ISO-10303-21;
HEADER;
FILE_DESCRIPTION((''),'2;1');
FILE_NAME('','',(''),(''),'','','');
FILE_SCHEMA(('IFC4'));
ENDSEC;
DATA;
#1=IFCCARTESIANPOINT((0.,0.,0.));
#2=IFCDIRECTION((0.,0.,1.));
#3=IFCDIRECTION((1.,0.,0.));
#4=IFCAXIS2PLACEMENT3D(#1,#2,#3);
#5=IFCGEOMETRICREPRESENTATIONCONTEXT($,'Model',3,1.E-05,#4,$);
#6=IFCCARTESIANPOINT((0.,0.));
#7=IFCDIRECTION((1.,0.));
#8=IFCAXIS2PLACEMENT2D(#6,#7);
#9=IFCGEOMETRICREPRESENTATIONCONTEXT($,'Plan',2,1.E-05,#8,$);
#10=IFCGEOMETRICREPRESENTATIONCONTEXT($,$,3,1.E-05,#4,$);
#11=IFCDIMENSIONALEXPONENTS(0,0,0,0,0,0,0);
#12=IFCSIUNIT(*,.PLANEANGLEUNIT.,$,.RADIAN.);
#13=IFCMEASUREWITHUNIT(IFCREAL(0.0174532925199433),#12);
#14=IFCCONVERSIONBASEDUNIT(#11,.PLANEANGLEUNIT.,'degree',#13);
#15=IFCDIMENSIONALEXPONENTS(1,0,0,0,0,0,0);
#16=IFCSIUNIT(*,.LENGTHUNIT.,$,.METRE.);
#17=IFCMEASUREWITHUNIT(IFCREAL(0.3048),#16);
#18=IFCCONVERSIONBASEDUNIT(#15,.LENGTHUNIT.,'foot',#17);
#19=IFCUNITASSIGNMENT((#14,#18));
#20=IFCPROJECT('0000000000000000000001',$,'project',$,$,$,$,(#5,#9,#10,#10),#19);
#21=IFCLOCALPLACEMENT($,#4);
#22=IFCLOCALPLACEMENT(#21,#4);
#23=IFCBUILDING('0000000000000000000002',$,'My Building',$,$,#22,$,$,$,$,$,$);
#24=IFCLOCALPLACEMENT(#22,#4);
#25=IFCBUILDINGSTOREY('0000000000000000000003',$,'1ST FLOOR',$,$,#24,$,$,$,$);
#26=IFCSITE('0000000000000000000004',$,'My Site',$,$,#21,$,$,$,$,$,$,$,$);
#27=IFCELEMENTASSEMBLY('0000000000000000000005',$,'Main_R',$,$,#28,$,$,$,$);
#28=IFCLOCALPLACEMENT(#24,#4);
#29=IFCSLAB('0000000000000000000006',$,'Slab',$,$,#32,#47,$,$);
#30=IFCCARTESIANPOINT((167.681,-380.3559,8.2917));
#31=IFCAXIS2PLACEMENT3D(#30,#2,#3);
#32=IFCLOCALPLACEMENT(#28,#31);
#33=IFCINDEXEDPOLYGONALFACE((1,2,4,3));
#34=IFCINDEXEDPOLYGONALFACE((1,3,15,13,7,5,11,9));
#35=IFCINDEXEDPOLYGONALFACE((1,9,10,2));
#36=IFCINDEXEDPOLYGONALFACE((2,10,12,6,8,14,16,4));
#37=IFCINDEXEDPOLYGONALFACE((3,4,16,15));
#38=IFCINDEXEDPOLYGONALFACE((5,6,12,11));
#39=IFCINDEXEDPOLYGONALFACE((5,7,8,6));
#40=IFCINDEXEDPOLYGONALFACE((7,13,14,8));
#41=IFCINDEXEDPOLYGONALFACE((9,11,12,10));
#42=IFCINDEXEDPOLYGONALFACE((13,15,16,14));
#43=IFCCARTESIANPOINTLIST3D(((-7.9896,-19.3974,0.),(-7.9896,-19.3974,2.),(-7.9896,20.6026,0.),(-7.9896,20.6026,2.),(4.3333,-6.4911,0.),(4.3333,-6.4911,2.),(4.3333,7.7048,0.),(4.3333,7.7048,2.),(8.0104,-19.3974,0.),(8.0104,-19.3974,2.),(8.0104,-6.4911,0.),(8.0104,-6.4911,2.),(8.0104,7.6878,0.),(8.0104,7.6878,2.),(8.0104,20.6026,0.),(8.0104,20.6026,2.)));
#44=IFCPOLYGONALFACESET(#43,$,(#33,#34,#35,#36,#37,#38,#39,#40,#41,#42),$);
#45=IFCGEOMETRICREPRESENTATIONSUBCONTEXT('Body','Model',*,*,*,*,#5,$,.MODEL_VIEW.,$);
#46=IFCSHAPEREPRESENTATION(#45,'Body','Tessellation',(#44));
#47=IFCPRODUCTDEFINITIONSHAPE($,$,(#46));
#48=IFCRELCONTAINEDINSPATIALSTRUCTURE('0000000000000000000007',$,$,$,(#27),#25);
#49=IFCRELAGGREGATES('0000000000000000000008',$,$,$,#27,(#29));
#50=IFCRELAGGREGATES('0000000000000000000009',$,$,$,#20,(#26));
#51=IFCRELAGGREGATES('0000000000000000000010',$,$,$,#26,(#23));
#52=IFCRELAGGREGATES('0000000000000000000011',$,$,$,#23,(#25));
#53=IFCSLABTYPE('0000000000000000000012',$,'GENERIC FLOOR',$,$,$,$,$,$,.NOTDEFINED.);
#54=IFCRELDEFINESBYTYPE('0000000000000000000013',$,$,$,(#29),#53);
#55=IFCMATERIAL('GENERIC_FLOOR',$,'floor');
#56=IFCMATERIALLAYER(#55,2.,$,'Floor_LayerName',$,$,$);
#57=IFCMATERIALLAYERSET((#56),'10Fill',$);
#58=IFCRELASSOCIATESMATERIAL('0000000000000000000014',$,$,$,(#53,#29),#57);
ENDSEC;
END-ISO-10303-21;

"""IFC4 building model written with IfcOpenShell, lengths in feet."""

from ifc_helpers import new_model, entity, si_unit, converted_unit, frame, origin_with_axes, origin_2d_with_axis, place, context, subcontext, project, spatial, line, indexed_curve, outline, extrude, material, layer, layer_set, layer_usage, type_object, element, aggregate, save


model = new_model("IFC4")

# Units and contexts
model_context = context("Model", 3, precision=1e-05, world=origin_with_axes())
plan_context = context("Plan", 2, precision=1e-05, world=origin_2d_with_axis())
context_of_model = context(None, 3, precision=1e-05, world=origin_with_axes())
body_context = subcontext(model_context, "Body", "Model", "MODEL_VIEW")
ifc_project = project(units=[converted_unit("PLANEANGLEUNIT", "degree", entity("IfcReal", 0.0174532925199433), si_unit("PLANEANGLEUNIT", "RADIAN"), dimensions=[0, 0, 0, 0, 0, 0, 0]), converted_unit("LENGTHUNIT", "foot", entity("IfcReal", 0.3048), si_unit("LENGTHUNIT", "METRE"), dimensions=[1, 0, 0, 0, 0, 0, 0])], contexts=[model_context, plan_context, context_of_model, context_of_model])

# Site, building, storey
site_placement = place(None, origin_with_axes())
site = spatial("IfcSite", under=ifc_project, at=site_placement, Name="My Site")
building_placement = place(site_placement, origin_with_axes())
building = spatial("IfcBuilding", under=site, at=building_placement, Name="My Building")
storey_placement = place(building_placement, origin_with_axes())
storey = spatial("IfcBuildingStorey", under=building, at=storey_placement, Name="1ST FLOOR")

# Element assembly, slab
assembly_1_placement = place(storey_placement, origin_with_axes())
assembly_1 = element("IfcElementAssembly", 1, at=assembly_1_placement, inside=storey, Name="Main_R")
ifc_material_1 = material(Name="GENERIC_FLOOR", Category="floor")
ifc_layer_1 = layer(ifc_material_1, 2.0, Name="Floor_LayerName")
ifc_layer_set_1 = layer_set([ifc_layer_1], Name="10Fill")
ifc_layer_usage_1 = layer_usage(ifc_layer_set_1, "AXIS3", "POSITIVE", 0.0)
slab_type = type_object("IfcSlabType", Name="GENERIC FLOOR", PredefinedType="NOTDEFINED", material=ifc_layer_set_1)
slab_placement = place(assembly_1_placement, frame((167.681, -380.3559, 8.2917), z_axis=(0.0, 0.0, 1.0), x_axis=(1.0, 0.0, 0.0)))
slab = element("IfcSlab", 2, at=slab_placement, type_object=slab_type, material=ifc_layer_usage_1, Name="Slab", context=body_context, shape_type="SweptSolid", body=[
    extrude(outline(indexed_curve([(-7.9896, -19.3974), (-7.9896, 20.6026), (8.0104, 20.6026), (8.0104, 7.6878), (4.3333, 7.7048), (4.3333, -6.4911), (8.0104, -6.4911), (8.0104, -19.3974)], segments=[line(5, 6), line(6, 7), line(7, 8), line(8, 1), line(1, 2), line(2, 3), line(3, 4), line(4, 5)], self_intersect=False)), None, (0.0, 0.0, 1.0), 2.0),
])

aggregate(assembly_1, [slab])

save(model, "model.ifc")
